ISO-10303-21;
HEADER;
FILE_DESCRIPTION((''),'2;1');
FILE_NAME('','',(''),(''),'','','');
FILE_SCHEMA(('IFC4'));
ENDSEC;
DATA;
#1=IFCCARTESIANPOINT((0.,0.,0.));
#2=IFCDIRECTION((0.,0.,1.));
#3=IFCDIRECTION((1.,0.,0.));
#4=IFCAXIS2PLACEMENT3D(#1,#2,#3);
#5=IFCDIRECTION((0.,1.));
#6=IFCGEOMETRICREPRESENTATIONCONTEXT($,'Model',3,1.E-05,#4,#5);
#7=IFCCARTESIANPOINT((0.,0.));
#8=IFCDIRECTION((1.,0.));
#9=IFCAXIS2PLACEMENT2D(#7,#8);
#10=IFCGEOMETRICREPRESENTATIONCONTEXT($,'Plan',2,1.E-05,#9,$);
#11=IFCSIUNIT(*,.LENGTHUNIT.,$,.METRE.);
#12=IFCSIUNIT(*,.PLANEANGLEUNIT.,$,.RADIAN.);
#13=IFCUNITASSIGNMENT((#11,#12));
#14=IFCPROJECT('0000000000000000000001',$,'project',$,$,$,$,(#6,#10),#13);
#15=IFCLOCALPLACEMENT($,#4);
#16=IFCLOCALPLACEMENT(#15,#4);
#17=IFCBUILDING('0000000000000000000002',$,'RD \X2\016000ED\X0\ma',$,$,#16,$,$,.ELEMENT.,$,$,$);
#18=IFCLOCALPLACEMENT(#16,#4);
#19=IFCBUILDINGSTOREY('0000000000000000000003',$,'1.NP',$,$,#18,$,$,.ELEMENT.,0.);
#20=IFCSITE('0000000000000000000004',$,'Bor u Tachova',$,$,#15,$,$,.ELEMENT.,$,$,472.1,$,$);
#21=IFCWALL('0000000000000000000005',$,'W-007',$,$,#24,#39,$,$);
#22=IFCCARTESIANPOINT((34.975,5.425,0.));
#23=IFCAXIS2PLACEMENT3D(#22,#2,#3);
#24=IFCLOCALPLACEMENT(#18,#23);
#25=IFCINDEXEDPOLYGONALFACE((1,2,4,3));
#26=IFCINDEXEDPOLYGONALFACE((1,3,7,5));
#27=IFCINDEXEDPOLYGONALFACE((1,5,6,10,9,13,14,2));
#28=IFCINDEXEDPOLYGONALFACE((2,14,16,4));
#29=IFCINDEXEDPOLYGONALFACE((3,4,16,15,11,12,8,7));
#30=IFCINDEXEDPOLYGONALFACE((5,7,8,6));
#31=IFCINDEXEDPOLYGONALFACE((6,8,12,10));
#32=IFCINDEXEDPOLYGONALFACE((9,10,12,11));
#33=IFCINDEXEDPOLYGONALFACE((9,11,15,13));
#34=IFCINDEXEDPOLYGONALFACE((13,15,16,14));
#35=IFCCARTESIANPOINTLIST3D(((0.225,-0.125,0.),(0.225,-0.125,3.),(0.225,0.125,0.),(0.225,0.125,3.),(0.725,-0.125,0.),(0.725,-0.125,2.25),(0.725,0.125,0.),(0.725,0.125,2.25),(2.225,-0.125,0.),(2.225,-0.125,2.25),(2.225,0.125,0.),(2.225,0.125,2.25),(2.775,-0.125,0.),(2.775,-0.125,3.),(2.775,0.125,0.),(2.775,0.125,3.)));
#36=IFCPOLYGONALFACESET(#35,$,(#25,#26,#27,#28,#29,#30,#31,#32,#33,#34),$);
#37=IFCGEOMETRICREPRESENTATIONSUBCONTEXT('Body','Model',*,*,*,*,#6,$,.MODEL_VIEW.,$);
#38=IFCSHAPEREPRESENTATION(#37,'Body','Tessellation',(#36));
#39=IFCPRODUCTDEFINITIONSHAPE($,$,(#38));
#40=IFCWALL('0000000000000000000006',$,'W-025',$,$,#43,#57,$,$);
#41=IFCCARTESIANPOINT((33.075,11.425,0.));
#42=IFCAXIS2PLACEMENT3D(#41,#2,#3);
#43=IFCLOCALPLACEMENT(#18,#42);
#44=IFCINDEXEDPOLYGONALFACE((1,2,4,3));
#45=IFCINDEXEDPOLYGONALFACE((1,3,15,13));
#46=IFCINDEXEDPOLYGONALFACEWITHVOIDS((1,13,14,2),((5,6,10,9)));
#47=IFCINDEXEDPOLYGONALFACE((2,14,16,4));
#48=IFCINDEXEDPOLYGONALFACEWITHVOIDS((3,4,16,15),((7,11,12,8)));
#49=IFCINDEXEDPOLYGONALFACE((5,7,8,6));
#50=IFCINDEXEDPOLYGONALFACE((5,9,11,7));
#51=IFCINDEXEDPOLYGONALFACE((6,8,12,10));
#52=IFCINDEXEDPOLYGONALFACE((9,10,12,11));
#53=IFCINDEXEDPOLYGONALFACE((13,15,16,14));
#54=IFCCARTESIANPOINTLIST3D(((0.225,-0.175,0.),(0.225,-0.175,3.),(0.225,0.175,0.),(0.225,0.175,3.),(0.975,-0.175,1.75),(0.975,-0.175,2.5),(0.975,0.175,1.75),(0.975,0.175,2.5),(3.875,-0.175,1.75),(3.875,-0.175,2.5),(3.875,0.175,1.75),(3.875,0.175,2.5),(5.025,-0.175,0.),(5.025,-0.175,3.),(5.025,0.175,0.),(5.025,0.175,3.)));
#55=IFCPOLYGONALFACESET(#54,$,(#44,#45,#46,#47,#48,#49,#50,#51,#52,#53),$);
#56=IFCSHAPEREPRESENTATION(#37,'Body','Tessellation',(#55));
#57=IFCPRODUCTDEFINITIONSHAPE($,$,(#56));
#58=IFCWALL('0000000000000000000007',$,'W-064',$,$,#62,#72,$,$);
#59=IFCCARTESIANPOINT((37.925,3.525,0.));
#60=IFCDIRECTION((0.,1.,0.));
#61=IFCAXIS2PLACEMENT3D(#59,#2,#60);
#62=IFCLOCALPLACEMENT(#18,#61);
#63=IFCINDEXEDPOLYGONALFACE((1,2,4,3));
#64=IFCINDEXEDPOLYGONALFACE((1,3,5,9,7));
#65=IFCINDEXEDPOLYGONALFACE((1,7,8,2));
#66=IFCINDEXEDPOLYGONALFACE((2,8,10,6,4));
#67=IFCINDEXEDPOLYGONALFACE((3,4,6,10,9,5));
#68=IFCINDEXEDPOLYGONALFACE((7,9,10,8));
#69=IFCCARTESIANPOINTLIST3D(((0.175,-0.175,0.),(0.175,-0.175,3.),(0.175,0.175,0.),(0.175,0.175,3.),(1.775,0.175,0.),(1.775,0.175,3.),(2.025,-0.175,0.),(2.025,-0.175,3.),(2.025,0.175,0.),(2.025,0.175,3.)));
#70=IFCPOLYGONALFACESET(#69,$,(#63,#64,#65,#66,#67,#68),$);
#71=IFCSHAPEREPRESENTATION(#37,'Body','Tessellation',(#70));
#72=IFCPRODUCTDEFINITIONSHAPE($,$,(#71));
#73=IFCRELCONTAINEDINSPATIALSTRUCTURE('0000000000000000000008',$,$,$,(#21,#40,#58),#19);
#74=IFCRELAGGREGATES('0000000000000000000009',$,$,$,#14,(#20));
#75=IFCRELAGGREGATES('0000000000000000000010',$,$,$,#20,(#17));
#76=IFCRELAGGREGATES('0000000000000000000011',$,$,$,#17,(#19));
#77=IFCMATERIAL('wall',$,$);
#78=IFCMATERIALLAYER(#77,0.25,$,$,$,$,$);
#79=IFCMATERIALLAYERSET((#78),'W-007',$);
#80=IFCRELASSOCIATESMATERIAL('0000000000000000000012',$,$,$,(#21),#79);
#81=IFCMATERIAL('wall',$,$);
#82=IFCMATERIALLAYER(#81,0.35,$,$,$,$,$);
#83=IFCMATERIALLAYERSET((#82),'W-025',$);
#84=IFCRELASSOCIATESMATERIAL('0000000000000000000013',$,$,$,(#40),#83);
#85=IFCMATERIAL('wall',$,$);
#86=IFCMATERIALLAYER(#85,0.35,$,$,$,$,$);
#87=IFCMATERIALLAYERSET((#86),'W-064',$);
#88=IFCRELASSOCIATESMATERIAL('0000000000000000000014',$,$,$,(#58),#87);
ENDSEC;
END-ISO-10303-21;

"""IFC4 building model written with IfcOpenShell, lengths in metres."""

from ifc_helpers import new_model, si_unit, direction, frame, frame_2d, origin_with_axes, origin_2d_with_axis, place, context, subcontext, project, spatial, line, indexed_curve, rectangle, outline, extrude, material, layer, layer_set, layer_usage, element, save


model = new_model("IFC4")

# Units and contexts
model_context = context("Model", 3, precision=1e-05, world=origin_with_axes(), true_north=direction((0.0, 1.0)))
plan_context = context("Plan", 2, precision=1e-05, world=origin_2d_with_axis())
body_context = subcontext(model_context, "Body", "Model", "MODEL_VIEW")
ifc_project = project(units=[si_unit("LENGTHUNIT", "METRE"), si_unit("PLANEANGLEUNIT", "RADIAN")], contexts=[model_context, plan_context])

# Site, building, storey
site_placement = place(None, origin_with_axes())
site = spatial("IfcSite", under=ifc_project, at=site_placement, Name="Bor u Tachova", CompositionType="ELEMENT", RefElevation=472.1)
building_placement = place(site_placement, origin_with_axes())
building = spatial("IfcBuilding", under=site, at=building_placement, Name="RD Šíma", CompositionType="ELEMENT")
storey_placement = place(building_placement, origin_with_axes())
storey = spatial("IfcBuildingStorey", under=building, at=storey_placement, Name="1.NP", CompositionType="ELEMENT", Elevation=0.0)

# Wall, opening
ifc_material_1 = material(Name="wall")
ifc_layer_1 = layer(ifc_material_1, 0.25)
ifc_layer_set_1 = layer_set([ifc_layer_1], Name="W-007")
ifc_layer_usage_1 = layer_usage(ifc_layer_set_1, "AXIS2", "POSITIVE", -0.125)
wall_1_placement = place(storey_placement, frame((34.975, 5.425, 0.0), z_axis=(0.0, 0.0, 1.0), x_axis=(1.0, 0.0, 0.0)))
wall_1 = element("IfcWall", 1, at=wall_1_placement, inside=storey, material=ifc_layer_usage_1, Name="W-007", context=body_context, shape_type="SweptSolid", body=[
    extrude(outline(indexed_curve([(0.225, -0.125), (0.225, 0.125), (2.775, 0.125), (2.775, -0.125)], segments=[line(1, 2, 3, 4, 1)])), origin_with_axes(), (0.0, 0.0, 1.0), 3.0),
])
opening_1_placement = place(wall_1_placement, frame((0.725, 0.0, 0.0), z_axis=(0.0, 0.0, 1.0), x_axis=(1.0, 0.0, 0.0)))
element("IfcOpeningElement", 2, at=opening_1_placement, cuts=wall_1, PredefinedType="OPENING", context=body_context, shape_type="SweptSolid", body=[
    extrude(rectangle(XDim=1.5, YDim=0.25, at=frame_2d((0.75, 0.0))), origin_with_axes(), (0.0, 0.0, 1.0), 2.25),
])

# Wall, opening
ifc_material_2 = material(Name="wall")
ifc_layer_2 = layer(ifc_material_2, 0.35)
ifc_layer_set_2 = layer_set([ifc_layer_2], Name="W-025")
ifc_layer_usage_2 = layer_usage(ifc_layer_set_2, "AXIS2", "POSITIVE", -0.175)
wall_2_placement = place(storey_placement, frame((33.075, 11.425, 0.0), z_axis=(0.0, 0.0, 1.0), x_axis=(1.0, 0.0, 0.0)))
wall_2 = element("IfcWall", 3, at=wall_2_placement, inside=storey, material=ifc_layer_usage_2, Name="W-025", context=body_context, shape_type="SweptSolid", body=[
    extrude(outline(indexed_curve([(0.225, -0.175), (0.225, 0.175), (4.675, 0.175), (5.025, 0.175), (5.025, -0.175)], segments=[line(1, 2, 3, 4, 5, 1)])), origin_with_axes(), (0.0, 0.0, 1.0), 3.0),
])
opening_2_placement = place(wall_2_placement, frame((0.975, 0.0, 1.75), z_axis=(0.0, 0.0, 1.0), x_axis=(1.0, 0.0, 0.0)))
element("IfcOpeningElement", 4, at=opening_2_placement, cuts=wall_2, PredefinedType="OPENING", context=body_context, shape_type="SweptSolid", body=[
    extrude(rectangle(XDim=2.9, YDim=0.35, at=frame_2d((1.45, 0.0))), origin_with_axes(), (0.0, 0.0, 1.0), 0.75),
])

# Wall
ifc_material_3 = material(Name="wall")
ifc_layer_3 = layer(ifc_material_3, 0.35)
ifc_layer_set_3 = layer_set([ifc_layer_3], Name="W-064")
ifc_layer_usage_3 = layer_usage(ifc_layer_set_3, "AXIS2", "POSITIVE", -0.175)
wall_3_placement = place(storey_placement, frame((37.925, 3.525, 0.0), z_axis=(0.0, 0.0, 1.0), x_axis=(0.0, 1.0, 0.0)))
element("IfcWall", 5, at=wall_3_placement, inside=storey, material=ifc_layer_usage_3, Name="W-064", context=body_context, shape_type="SweptSolid", body=[
    extrude(outline(indexed_curve([(0.175, -0.175), (0.175, 0.175), (1.775, 0.175), (2.025, 0.175), (2.025, -0.175)], segments=[line(1, 2, 3, 4, 5, 1)])), origin_with_axes(), (0.0, 0.0, 1.0), 3.0),
])

save(model, "model.ifc")
